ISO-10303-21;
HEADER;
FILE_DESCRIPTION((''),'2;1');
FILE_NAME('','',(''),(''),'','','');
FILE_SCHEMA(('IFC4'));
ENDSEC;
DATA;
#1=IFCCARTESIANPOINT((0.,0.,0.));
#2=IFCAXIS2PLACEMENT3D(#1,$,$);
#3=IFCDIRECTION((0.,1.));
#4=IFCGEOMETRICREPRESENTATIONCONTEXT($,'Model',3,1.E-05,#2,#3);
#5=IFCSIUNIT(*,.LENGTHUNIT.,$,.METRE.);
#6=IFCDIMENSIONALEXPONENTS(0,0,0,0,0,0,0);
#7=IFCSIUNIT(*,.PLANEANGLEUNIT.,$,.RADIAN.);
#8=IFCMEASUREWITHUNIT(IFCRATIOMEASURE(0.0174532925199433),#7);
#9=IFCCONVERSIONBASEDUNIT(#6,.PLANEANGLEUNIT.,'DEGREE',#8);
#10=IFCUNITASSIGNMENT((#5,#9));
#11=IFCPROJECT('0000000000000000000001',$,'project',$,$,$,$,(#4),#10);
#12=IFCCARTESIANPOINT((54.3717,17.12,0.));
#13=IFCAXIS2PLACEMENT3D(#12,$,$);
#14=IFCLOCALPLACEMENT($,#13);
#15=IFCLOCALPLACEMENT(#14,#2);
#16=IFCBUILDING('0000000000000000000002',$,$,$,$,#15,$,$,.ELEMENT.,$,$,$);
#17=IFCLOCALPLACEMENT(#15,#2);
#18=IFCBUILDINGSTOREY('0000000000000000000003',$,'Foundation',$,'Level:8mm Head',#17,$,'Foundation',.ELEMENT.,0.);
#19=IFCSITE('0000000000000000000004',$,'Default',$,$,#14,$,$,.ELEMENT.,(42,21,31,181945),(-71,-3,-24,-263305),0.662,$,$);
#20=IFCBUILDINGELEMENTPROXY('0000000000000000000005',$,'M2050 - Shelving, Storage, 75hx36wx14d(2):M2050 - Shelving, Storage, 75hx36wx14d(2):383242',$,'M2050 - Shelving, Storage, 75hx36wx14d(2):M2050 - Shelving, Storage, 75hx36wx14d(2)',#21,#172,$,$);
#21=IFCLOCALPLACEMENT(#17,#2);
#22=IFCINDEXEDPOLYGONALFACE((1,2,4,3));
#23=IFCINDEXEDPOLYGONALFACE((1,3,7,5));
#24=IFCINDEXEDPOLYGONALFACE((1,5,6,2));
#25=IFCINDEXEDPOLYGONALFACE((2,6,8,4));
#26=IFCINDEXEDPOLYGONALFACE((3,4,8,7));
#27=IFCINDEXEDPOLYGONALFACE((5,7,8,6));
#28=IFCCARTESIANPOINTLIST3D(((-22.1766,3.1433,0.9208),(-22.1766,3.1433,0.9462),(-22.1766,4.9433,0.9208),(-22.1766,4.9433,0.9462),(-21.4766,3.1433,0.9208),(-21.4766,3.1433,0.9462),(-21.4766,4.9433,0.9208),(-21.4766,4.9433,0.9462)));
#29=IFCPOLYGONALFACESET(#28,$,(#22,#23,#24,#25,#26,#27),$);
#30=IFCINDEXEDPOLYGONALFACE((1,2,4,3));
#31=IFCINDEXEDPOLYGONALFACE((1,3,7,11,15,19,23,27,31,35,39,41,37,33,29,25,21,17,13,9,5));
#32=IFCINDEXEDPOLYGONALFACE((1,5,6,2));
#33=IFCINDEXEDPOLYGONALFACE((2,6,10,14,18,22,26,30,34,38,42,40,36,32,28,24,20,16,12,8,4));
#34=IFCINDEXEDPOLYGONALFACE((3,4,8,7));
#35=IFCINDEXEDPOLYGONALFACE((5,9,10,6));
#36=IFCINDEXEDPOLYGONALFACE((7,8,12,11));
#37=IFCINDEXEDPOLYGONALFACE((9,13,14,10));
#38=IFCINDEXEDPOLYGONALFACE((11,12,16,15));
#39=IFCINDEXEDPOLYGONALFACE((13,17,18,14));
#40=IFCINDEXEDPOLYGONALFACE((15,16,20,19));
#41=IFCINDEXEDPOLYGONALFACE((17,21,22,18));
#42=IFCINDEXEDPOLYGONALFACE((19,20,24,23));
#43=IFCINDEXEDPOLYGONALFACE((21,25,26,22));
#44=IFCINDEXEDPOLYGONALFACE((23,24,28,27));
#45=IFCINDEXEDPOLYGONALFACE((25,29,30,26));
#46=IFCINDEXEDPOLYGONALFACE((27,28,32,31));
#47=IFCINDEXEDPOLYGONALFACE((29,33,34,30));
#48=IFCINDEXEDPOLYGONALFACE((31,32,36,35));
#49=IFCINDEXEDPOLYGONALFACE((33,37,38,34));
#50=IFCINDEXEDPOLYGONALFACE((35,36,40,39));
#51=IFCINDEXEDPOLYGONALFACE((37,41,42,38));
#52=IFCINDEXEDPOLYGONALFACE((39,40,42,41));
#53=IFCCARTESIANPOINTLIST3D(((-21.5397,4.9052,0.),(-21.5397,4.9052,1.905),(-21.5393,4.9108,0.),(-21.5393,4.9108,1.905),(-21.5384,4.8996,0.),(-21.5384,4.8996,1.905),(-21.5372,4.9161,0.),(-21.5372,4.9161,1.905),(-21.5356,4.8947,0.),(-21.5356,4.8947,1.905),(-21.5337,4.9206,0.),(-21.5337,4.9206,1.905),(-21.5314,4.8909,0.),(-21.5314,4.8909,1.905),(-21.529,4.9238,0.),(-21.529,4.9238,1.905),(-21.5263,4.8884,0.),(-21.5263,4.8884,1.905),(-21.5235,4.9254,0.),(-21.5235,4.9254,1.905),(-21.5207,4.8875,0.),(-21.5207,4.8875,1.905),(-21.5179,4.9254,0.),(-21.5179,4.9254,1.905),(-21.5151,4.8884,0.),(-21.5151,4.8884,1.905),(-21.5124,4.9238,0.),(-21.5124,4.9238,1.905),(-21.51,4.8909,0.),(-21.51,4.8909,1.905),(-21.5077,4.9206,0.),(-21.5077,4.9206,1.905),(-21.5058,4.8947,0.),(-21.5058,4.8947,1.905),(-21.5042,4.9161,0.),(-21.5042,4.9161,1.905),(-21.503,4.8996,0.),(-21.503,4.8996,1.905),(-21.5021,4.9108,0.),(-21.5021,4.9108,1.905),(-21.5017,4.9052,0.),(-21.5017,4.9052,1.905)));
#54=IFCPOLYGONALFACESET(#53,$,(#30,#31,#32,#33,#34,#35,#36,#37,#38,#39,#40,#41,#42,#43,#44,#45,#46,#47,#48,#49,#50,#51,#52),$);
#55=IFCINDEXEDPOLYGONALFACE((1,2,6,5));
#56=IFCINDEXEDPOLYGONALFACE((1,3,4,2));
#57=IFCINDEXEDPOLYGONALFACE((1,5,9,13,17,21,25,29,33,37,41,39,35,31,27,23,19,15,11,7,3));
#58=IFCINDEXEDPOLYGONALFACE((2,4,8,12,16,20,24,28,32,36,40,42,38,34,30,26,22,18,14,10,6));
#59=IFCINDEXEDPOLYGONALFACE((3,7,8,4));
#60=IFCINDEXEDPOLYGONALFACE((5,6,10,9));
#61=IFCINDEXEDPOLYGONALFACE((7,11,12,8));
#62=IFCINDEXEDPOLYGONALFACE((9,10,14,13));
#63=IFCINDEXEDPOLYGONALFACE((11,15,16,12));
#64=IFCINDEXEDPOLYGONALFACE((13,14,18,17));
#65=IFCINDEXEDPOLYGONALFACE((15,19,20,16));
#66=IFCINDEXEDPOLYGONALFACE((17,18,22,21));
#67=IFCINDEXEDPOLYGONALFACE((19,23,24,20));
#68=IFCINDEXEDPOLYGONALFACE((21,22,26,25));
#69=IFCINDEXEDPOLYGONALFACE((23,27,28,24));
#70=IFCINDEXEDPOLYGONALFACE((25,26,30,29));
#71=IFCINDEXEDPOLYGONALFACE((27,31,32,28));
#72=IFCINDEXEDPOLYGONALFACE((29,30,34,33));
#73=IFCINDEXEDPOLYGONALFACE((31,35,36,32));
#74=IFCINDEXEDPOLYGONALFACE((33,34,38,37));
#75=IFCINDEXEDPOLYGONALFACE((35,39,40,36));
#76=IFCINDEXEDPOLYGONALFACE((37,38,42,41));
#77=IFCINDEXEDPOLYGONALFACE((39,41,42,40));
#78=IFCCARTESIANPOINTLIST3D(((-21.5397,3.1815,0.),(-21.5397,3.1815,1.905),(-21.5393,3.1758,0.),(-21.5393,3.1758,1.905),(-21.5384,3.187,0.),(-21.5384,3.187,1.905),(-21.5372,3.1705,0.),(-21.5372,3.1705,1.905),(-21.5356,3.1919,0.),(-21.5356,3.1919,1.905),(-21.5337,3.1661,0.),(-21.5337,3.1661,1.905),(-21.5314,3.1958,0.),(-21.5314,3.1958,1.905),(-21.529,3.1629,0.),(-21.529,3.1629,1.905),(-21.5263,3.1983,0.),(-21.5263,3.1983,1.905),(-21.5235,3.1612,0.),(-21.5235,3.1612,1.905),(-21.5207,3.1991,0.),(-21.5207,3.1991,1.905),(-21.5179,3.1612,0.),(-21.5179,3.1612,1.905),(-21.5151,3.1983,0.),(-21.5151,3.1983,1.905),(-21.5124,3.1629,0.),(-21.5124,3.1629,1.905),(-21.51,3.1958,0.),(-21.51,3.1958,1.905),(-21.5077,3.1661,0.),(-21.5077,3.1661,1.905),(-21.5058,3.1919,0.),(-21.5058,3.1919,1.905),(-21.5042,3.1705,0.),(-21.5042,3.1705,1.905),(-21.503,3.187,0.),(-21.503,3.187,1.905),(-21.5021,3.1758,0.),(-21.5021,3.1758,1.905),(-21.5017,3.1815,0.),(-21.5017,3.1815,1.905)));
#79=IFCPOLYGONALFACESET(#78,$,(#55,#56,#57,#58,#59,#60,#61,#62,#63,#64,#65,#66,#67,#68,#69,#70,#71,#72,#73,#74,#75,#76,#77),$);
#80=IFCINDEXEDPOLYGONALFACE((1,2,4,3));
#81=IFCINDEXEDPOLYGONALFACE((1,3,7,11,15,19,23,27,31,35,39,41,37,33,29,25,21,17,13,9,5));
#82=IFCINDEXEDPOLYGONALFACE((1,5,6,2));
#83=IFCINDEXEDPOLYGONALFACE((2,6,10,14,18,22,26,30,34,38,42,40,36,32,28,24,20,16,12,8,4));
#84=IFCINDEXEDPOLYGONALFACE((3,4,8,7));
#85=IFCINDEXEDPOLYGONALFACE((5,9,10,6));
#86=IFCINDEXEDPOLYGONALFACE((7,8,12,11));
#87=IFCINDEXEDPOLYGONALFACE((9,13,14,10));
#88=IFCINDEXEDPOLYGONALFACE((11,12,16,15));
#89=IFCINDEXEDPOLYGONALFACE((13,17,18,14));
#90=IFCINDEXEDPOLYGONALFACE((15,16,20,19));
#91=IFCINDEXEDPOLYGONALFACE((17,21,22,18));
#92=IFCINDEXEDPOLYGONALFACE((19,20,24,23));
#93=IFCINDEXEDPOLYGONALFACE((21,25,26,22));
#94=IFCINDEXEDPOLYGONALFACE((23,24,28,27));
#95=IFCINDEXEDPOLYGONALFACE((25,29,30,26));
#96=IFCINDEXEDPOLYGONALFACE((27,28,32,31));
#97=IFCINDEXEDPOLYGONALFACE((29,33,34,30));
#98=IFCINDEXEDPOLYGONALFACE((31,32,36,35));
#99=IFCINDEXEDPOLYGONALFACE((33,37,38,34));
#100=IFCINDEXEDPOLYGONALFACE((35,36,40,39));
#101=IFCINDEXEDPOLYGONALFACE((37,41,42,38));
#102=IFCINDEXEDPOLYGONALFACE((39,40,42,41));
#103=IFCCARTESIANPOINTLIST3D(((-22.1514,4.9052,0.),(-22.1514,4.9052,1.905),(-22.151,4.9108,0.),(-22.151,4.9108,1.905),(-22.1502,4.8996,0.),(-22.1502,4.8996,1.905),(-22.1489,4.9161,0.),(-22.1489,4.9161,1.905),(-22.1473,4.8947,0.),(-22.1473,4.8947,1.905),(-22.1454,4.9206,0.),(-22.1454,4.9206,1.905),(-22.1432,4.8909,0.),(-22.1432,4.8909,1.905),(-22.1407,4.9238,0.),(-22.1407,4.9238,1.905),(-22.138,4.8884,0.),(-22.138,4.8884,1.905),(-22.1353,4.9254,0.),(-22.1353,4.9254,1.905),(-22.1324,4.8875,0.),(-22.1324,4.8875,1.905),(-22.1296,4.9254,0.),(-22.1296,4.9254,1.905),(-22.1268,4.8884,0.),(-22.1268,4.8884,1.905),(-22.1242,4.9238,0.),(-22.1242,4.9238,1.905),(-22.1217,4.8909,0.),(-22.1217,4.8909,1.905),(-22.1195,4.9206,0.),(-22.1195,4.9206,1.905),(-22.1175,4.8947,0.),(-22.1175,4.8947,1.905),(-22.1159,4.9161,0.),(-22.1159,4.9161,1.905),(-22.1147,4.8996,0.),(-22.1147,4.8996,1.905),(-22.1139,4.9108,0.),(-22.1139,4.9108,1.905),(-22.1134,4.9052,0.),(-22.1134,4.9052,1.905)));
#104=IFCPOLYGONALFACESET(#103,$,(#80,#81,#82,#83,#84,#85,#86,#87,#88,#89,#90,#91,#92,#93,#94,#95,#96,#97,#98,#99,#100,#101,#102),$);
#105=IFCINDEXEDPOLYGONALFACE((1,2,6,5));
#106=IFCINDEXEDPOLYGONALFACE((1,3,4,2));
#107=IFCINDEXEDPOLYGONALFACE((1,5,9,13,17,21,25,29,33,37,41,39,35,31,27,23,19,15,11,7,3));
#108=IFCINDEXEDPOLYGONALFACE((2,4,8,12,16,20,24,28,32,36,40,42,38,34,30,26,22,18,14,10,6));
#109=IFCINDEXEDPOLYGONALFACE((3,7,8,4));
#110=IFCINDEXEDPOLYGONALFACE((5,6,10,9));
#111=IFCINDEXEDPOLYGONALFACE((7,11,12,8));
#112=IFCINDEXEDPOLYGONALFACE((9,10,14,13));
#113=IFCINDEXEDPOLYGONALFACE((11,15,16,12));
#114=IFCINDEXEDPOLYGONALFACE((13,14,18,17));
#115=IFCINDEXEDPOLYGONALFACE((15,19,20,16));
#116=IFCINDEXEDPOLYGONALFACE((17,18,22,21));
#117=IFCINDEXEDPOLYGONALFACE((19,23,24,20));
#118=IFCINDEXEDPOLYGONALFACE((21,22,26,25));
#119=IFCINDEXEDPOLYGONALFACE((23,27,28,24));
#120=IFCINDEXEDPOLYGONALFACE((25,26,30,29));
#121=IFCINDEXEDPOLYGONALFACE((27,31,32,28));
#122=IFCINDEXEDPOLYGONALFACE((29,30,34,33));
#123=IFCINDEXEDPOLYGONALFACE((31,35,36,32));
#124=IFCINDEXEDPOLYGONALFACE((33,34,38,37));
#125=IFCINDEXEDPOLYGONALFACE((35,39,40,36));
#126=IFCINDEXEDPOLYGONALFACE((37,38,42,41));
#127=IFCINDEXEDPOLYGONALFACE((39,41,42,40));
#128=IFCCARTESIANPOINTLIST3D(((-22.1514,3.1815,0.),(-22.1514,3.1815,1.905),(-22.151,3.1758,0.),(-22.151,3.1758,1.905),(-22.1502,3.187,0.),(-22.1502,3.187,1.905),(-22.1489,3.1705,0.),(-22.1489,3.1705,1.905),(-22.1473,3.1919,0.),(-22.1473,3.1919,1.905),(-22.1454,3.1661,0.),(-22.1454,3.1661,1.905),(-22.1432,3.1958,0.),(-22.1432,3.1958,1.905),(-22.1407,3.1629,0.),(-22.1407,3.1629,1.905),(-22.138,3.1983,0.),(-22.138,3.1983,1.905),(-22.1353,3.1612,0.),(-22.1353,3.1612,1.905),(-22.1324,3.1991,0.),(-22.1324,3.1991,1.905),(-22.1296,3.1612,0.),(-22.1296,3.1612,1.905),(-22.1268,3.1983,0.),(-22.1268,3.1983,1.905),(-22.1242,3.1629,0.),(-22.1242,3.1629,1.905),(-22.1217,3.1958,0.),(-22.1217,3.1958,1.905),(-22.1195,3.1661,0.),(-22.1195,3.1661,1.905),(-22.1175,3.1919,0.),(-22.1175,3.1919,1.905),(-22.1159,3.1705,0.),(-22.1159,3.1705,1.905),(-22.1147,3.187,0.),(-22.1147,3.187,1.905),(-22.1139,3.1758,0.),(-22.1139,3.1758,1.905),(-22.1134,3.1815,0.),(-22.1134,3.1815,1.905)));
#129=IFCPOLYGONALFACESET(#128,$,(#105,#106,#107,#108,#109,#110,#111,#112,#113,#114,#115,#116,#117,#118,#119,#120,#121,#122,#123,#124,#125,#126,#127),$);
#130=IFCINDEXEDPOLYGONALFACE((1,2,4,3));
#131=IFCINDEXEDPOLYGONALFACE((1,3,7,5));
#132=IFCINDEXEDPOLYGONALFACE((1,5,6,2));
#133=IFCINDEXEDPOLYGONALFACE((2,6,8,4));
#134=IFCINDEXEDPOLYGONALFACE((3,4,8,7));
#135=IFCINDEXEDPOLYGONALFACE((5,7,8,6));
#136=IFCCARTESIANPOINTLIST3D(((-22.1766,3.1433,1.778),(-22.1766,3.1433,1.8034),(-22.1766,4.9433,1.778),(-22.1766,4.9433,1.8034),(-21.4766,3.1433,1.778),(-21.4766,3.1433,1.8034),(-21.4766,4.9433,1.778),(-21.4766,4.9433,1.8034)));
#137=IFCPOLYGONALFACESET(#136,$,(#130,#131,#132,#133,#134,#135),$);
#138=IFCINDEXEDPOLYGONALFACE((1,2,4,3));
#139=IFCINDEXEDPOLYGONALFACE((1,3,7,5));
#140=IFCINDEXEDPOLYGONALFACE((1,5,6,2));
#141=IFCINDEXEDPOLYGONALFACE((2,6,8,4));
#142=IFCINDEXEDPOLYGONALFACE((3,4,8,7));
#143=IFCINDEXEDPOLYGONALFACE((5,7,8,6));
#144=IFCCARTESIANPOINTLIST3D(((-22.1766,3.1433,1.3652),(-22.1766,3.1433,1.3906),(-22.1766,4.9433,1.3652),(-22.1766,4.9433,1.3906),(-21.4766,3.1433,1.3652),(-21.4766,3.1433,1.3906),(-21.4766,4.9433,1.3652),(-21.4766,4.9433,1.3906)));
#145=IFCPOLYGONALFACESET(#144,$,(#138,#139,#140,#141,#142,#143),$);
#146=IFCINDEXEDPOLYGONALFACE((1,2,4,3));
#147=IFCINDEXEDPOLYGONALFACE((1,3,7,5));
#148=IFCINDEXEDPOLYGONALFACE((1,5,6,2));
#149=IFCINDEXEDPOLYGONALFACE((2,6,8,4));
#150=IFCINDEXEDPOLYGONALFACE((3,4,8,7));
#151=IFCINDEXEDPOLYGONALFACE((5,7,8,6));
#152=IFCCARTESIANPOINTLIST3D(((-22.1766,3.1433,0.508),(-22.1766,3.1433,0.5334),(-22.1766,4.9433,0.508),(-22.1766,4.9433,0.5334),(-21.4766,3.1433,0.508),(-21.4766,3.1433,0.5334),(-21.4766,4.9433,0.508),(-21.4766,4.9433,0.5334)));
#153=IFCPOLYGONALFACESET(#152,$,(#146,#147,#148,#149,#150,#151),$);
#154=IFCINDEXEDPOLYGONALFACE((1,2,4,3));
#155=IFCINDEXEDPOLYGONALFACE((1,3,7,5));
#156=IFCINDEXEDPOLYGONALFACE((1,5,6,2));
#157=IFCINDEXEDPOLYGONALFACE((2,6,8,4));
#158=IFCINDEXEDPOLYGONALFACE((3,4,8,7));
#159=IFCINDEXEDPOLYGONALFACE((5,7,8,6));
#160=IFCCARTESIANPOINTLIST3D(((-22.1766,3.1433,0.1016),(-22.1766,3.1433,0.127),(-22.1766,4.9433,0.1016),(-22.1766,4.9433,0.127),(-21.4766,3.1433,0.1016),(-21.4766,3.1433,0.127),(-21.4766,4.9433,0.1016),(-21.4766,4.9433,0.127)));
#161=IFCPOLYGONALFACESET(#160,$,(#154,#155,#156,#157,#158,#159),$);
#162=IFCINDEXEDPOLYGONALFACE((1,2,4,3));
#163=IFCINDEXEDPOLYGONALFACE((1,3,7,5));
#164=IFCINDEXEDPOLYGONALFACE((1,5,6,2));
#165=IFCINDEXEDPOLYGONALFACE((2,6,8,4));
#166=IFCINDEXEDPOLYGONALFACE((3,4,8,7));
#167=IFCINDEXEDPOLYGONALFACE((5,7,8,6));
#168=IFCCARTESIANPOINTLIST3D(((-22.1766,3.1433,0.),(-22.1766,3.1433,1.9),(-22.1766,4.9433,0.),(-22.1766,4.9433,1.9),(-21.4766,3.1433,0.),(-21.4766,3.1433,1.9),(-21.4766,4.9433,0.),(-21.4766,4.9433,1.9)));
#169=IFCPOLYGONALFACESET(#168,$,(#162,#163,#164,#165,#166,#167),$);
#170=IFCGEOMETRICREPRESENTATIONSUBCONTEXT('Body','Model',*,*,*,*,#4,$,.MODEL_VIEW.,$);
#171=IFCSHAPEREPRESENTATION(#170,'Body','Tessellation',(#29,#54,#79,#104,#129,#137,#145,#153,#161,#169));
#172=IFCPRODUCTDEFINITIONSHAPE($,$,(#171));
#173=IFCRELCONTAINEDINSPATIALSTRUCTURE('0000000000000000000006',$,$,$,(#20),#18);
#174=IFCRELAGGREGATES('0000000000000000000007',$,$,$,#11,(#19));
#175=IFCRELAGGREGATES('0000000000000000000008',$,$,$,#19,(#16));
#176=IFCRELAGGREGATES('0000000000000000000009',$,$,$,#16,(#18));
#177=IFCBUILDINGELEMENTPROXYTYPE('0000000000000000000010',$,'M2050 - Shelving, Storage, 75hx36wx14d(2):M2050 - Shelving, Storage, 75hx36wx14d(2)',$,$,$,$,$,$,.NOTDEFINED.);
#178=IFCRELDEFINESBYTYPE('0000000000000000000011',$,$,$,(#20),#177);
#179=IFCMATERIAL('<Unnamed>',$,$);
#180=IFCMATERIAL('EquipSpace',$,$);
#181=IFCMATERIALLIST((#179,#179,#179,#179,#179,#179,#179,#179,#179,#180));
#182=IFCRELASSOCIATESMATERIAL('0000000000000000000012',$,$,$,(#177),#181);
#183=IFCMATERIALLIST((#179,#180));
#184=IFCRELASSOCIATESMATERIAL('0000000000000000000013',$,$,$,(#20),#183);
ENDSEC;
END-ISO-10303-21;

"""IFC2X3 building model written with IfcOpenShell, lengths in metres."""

from ifc_helpers import new_model, entity, si_unit, converted_unit, direction, frame, frame_2d, origin, origin_2d_with_axis, place, context, subcontext, project, spatial, rectangle, circle, extrude, source, transform, mapped, material, material_list, type_object, type_shapes, element, save


model = new_model("IFC2X3")

# Units and contexts
model_context = context("Model", 3, precision=1e-05, world=origin(), true_north=direction((0.0, 1.0)))
body_context = subcontext(model_context, "Body", "Model", "MODEL_VIEW")
ifc_project = project(units=[si_unit("LENGTHUNIT", "METRE"), converted_unit("PLANEANGLEUNIT", "DEGREE", entity("IfcRatioMeasure", 0.0174532925199433), si_unit("PLANEANGLEUNIT", "RADIAN"), dimensions=[0, 0, 0, 0, 0, 0, 0])], contexts=[model_context])

# Site, building, storey
site_placement = place(None, frame((54.3717, 17.12, 0.0)))
site = spatial("IfcSite", under=ifc_project, at=site_placement, Name="Default", CompositionType="ELEMENT", RefLatitude=(42, 21, 31, 181945), RefLongitude=(-71, -3, -24, -263305), RefElevation=0.662)
building_placement = place(site_placement, origin())
building = spatial("IfcBuilding", under=site, at=building_placement, CompositionType="ELEMENT")
storey_placement = place(building_placement, origin())
storey = spatial("IfcBuildingStorey", under=building, at=storey_placement, Name="Foundation", ObjectType="Level:8mm Head", LongName="Foundation", CompositionType="ELEMENT", Elevation=0.0)

# Building element proxy
ifc_material_1 = material(Name="<Unnamed>")
ifc_material_2 = material(Name="EquipSpace")
ifc_material_list_1 = material_list([ifc_material_1, ifc_material_1, ifc_material_1, ifc_material_1, ifc_material_1, ifc_material_1, ifc_material_1, ifc_material_1, ifc_material_1, ifc_material_2])
building_element_proxy_type = type_object("IfcBuildingElementProxyType", Name="M2050 - Shelving, Storage, 75hx36wx14d(2):M2050 - Shelving, Storage, 75hx36wx14d(2)", PredefinedType="NOTDEFINED", material=ifc_material_list_1)
shared_shape = source(origin(), body_context, "Body", "SweptSolid", [
    extrude(rectangle(XDim=1.8, YDim=0.7, at=origin_2d_with_axis()), frame((0.0, 0.0, 0.9207), z_axis=(0.0, 0.0, 1.0), x_axis=(-1.0, 0.0, 0.0)), (0.0, 0.0, 1.0), 0.0254),
    extrude(circle(Radius=0.0191, at=origin_2d_with_axis()), frame((0.8633, -0.3059, 0.0), z_axis=(0.0, 0.0, 1.0), x_axis=(-1.0, 0.0, 0.0)), (0.0, 0.0, 1.0), 1.905),
    extrude(circle(Radius=0.0191, at=origin_2d_with_axis()), frame((-0.8633, -0.3059, 0.0)), (0.0, 0.0, 1.0), 1.905),
    extrude(circle(Radius=0.0191, at=origin_2d_with_axis()), frame((0.8633, 0.3059, 0.0), z_axis=(0.0, 0.0, 1.0), x_axis=(-1.0, 0.0, 0.0)), (0.0, 0.0, 1.0), 1.905),
    extrude(circle(Radius=0.0191, at=origin_2d_with_axis()), frame((-0.8633, 0.3059, 0.0)), (0.0, 0.0, 1.0), 1.905),
    extrude(rectangle(XDim=1.8, YDim=0.7, at=origin_2d_with_axis()), frame((0.0, 0.0, 1.778), z_axis=(0.0, 0.0, 1.0), x_axis=(-1.0, 0.0, 0.0)), (0.0, 0.0, 1.0), 0.0254),
    extrude(rectangle(XDim=1.8, YDim=0.7, at=origin_2d_with_axis()), frame((0.0, 0.0, 1.3653), z_axis=(0.0, 0.0, 1.0), x_axis=(-1.0, 0.0, 0.0)), (0.0, 0.0, 1.0), 0.0254),
    extrude(rectangle(XDim=1.8, YDim=0.7, at=origin_2d_with_axis()), frame((0.0, 0.0, 0.508), z_axis=(0.0, 0.0, 1.0), x_axis=(-1.0, 0.0, 0.0)), (0.0, 0.0, 1.0), 0.0254),
    extrude(rectangle(XDim=1.8, YDim=0.7, at=origin_2d_with_axis()), frame((0.0, 0.0, 0.1016), z_axis=(0.0, 0.0, 1.0), x_axis=(-1.0, 0.0, 0.0)), (0.0, 0.0, 1.0), 0.0254),
    extrude(rectangle(XDim=0.7, YDim=1.8, at=frame_2d((0.0, 0.18), x_axis=(1.0, 0.0))), frame((-0.18, 0.0, 0.0), z_axis=(0.0, 0.0, 1.0), x_axis=(0.0, -1.0, 0.0)), (0.0, 0.0, 1.0), 1.9),
])
type_shapes(building_element_proxy_type, [shared_shape])
ifc_material_list_2 = material_list([ifc_material_1, ifc_material_2])
proxy_1_placement = place(storey_placement, frame((-21.8266, 4.0433, 0.0), z_axis=(0.0, 0.0, 1.0), x_axis=(0.0, 1.0, 0.0)))
element("IfcBuildingElementProxy", 1, at=proxy_1_placement, inside=storey, type_object=building_element_proxy_type, material=ifc_material_list_2, Name="M2050 - Shelving, Storage, 75hx36wx14d(2):M2050 - Shelving, Storage, 75hx36wx14d(2):383242", ObjectType="M2050 - Shelving, Storage, 75hx36wx14d(2):M2050 - Shelving, Storage, 75hx36wx14d(2)", context=body_context, shape_type="MappedRepresentation", body=[
    mapped(shared_shape, transform((0.0, 0.0, 0.0), scale=1.0)),
])

save(model, "model.ifc")
